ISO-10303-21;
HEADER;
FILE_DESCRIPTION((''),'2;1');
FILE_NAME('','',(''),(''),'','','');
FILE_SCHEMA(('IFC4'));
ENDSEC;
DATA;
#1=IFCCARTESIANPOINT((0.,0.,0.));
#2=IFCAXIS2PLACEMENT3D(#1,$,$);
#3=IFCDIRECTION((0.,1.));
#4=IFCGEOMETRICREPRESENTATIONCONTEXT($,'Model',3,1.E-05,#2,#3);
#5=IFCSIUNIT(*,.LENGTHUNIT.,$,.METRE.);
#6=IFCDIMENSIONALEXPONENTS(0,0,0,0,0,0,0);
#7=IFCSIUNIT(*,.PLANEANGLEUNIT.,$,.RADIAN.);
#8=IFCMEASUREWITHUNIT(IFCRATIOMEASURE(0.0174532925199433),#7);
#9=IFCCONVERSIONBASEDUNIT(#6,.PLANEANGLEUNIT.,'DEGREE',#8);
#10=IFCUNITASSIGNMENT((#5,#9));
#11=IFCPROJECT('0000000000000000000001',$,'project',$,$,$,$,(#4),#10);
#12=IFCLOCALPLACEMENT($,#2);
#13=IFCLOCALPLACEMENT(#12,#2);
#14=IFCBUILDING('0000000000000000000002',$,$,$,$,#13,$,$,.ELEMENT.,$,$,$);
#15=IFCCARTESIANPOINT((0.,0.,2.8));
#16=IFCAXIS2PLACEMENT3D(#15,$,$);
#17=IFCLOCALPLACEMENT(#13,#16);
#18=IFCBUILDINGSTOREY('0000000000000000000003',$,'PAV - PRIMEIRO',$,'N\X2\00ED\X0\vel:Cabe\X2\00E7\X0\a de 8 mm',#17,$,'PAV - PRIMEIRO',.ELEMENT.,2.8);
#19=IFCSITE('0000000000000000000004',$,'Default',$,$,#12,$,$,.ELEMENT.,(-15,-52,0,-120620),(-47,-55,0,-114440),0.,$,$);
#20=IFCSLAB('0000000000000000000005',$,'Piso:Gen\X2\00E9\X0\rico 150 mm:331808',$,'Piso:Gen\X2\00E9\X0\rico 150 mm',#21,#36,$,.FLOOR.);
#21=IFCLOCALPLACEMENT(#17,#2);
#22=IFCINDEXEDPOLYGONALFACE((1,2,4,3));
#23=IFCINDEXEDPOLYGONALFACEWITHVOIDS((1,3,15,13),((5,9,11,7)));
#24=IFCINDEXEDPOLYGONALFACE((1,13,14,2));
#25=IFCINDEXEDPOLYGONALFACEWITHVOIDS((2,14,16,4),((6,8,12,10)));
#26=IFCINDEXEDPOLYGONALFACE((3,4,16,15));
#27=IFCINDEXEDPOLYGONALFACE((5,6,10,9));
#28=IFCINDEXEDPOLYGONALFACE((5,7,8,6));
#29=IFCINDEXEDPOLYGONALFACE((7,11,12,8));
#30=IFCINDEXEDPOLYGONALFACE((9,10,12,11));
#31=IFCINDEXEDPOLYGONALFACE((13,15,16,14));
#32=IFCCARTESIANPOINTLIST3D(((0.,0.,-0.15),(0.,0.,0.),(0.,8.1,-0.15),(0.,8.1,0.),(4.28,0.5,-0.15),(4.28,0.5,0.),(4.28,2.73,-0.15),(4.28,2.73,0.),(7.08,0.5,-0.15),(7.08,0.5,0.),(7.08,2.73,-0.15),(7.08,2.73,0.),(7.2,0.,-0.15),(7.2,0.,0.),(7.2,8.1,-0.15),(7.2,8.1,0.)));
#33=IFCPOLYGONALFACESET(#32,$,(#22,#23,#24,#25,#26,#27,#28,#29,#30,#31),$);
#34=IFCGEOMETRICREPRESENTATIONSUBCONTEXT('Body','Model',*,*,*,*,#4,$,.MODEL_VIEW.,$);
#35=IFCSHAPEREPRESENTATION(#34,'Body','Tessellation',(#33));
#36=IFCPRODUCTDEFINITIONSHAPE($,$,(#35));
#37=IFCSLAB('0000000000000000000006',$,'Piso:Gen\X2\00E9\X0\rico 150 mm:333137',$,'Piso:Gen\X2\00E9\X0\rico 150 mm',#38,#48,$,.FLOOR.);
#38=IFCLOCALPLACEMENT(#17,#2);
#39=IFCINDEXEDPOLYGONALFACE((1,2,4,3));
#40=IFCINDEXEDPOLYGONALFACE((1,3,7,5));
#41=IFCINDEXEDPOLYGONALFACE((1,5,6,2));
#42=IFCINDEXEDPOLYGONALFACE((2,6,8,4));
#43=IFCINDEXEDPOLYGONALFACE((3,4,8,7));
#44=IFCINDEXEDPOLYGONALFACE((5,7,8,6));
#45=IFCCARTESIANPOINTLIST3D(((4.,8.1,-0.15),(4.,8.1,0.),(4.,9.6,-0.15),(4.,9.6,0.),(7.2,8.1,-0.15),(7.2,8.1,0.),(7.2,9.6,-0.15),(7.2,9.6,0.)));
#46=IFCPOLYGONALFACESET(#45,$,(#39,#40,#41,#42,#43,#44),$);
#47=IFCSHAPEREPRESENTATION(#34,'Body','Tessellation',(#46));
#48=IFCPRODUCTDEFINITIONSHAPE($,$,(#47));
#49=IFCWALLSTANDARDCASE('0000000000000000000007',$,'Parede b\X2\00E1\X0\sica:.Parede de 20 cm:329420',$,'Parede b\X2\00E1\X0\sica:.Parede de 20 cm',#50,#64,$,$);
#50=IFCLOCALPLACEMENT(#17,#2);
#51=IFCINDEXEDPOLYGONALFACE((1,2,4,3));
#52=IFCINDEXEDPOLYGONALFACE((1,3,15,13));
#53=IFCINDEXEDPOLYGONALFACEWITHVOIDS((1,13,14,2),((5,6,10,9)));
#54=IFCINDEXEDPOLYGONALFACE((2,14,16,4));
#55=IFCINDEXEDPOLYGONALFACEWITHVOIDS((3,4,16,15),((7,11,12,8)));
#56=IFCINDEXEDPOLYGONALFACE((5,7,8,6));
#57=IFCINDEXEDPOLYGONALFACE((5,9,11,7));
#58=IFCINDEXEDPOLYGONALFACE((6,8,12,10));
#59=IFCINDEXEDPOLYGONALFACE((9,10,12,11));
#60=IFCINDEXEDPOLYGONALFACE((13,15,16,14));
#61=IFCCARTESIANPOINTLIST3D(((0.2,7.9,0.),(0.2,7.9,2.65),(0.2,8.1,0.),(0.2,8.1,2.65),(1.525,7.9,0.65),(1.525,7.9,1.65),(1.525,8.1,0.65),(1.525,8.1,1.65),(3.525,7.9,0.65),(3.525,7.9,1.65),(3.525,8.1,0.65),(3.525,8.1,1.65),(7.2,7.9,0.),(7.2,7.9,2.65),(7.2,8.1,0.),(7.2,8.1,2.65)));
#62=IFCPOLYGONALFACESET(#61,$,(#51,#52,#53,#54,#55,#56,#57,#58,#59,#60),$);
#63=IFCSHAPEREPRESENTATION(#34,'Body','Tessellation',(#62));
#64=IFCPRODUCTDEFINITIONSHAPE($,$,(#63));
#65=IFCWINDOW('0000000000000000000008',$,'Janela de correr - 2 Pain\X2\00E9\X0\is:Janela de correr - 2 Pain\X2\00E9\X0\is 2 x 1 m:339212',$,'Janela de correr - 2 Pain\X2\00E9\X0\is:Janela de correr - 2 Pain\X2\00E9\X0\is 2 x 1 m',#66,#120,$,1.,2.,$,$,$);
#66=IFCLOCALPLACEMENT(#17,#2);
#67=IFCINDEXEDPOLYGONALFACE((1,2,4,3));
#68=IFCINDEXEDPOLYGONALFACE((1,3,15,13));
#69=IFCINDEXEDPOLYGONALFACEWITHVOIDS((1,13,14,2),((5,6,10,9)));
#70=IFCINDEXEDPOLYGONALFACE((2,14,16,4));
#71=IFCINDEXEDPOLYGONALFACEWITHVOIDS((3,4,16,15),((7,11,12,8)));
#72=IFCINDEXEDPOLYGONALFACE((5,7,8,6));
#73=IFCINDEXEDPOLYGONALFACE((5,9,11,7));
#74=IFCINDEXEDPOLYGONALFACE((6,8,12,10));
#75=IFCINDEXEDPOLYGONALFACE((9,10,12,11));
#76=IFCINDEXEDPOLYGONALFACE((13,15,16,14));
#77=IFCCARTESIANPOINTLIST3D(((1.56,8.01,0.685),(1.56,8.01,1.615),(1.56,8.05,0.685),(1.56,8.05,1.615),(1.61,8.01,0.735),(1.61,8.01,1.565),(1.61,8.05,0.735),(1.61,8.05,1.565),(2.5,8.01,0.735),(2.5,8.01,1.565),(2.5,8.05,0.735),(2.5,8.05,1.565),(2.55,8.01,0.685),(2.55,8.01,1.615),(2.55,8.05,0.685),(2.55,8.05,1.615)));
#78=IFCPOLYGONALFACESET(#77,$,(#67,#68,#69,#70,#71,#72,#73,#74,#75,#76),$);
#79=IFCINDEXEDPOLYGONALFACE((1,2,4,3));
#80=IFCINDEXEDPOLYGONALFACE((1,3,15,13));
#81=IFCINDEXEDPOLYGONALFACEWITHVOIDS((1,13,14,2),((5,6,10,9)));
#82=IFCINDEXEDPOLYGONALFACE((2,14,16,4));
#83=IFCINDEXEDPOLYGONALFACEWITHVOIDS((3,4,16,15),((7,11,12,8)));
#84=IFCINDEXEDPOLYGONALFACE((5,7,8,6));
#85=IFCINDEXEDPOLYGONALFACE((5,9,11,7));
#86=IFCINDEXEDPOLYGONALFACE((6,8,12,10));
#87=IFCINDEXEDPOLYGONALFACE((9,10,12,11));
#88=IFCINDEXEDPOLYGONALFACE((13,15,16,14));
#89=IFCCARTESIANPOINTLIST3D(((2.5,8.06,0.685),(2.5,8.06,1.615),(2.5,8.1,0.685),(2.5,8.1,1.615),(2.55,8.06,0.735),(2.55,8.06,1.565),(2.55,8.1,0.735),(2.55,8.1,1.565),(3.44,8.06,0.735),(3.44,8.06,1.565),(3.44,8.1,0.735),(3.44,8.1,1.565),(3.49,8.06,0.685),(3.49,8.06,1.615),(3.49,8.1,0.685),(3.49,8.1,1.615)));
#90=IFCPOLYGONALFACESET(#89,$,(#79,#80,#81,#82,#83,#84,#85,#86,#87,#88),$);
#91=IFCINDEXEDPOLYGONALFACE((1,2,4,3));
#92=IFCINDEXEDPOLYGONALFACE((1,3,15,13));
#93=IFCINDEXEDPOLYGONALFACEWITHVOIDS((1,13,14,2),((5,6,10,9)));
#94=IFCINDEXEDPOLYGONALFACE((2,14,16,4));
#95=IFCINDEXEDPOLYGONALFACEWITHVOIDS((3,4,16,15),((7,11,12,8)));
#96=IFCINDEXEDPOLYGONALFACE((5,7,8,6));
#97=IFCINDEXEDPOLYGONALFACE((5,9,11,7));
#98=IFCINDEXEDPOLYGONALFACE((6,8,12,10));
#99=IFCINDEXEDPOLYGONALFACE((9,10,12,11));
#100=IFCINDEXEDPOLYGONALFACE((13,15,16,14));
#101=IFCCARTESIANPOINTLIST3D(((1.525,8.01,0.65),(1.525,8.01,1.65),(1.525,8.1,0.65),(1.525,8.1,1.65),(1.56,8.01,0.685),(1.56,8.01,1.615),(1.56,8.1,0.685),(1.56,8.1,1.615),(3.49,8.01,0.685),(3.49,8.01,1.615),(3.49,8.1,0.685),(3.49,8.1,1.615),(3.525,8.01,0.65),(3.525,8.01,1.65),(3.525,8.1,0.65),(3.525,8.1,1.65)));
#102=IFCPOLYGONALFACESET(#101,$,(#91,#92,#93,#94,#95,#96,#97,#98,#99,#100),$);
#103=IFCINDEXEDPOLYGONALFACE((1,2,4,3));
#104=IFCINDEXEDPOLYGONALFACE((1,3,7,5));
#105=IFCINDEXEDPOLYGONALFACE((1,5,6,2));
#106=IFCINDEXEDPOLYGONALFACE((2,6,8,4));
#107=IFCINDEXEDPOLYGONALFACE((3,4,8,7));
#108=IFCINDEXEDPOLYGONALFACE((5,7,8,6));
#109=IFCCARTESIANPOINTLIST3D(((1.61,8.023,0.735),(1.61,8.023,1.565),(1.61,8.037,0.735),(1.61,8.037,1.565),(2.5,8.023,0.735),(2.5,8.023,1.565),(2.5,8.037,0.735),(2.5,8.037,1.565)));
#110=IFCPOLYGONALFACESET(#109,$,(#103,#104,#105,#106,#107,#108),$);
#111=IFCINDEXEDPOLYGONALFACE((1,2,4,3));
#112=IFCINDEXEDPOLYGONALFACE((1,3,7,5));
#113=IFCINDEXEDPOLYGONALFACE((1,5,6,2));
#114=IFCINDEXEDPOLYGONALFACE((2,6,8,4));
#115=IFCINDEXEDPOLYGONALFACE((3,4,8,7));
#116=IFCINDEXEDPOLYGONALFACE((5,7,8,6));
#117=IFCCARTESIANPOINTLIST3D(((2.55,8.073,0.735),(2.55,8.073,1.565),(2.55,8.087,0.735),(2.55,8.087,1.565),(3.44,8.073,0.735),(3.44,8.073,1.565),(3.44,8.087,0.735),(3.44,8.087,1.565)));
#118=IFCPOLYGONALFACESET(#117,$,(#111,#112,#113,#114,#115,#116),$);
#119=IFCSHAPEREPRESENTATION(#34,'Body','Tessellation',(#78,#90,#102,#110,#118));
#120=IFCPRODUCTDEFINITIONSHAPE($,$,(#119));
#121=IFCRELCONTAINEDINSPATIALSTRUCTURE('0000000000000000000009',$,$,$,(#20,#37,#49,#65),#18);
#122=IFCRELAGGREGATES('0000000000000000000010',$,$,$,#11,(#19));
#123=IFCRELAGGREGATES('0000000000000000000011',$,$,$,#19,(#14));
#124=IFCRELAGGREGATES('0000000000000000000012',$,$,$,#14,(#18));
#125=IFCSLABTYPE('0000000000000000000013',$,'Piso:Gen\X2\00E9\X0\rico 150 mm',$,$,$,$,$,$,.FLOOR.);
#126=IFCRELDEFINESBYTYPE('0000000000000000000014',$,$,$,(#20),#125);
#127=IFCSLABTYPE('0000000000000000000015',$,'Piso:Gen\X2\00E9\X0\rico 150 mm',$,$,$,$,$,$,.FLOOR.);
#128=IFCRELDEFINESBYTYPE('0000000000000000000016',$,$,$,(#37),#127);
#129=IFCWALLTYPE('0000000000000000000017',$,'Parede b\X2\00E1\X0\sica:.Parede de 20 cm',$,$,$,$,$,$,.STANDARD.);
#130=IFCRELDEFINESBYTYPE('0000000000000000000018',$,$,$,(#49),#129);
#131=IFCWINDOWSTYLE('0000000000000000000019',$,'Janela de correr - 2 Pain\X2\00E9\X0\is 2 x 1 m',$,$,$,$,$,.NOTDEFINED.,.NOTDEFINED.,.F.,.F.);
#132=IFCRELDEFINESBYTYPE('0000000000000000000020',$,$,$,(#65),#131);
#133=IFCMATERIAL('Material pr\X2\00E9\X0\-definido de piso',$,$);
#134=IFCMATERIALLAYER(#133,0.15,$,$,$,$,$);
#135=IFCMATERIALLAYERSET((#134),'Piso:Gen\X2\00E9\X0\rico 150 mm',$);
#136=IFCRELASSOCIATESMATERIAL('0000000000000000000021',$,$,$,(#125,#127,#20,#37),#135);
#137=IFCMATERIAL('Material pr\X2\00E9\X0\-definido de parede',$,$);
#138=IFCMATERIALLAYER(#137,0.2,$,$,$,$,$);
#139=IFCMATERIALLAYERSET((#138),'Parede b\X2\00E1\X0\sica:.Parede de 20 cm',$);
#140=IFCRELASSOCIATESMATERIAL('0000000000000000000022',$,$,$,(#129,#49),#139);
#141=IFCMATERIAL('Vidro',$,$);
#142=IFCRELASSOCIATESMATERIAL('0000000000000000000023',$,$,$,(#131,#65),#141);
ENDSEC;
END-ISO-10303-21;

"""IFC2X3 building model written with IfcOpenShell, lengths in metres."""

from ifc_helpers import new_model, entity, si_unit, converted_unit, direction, frame, frame_2d, origin, origin_2d_with_axis, place, context, subcontext, project, spatial, polyline, rectangle, outline, extrude, clip, bounded_halfspace, source, transform, mapped, material, layer, layer_set, layer_usage, type_object, type_shapes, element, fill, save


model = new_model("IFC2X3")

# Units and contexts
model_context = context("Model", 3, precision=1e-05, world=origin(), true_north=direction((0.0, 1.0)))
body_context = subcontext(model_context, "Body", "Model", "MODEL_VIEW")
ifc_project = project(units=[si_unit("LENGTHUNIT", "METRE"), converted_unit("PLANEANGLEUNIT", "DEGREE", entity("IfcRatioMeasure", 0.0174532925199433), si_unit("PLANEANGLEUNIT", "RADIAN"), dimensions=[0, 0, 0, 0, 0, 0, 0])], contexts=[model_context])

# Site, building, storey
site_placement = place(None, origin())
site = spatial("IfcSite", under=ifc_project, at=site_placement, Name="Default", CompositionType="ELEMENT", RefLatitude=(-15, -52, 0, -120620), RefLongitude=(-47, -55, 0, -114440), RefElevation=0.0)
building_placement = place(site_placement, origin())
building = spatial("IfcBuilding", under=site, at=building_placement, CompositionType="ELEMENT")
storey_placement = place(building_placement, frame((0.0, 0.0, 2.8)))
storey = spatial("IfcBuildingStorey", under=building, at=storey_placement, Name="PAV - PRIMEIRO", ObjectType="Nível:Cabeça de 8 mm", LongName="PAV - PRIMEIRO", CompositionType="ELEMENT", Elevation=2.8)

# Slab, opening
ifc_material_1 = material(Name="Material pré-definido de piso")
ifc_layer_1 = layer(ifc_material_1, 0.15)
ifc_layer_set_1 = layer_set([ifc_layer_1], Name="Piso:Genérico 150 mm")
ifc_layer_usage_1 = layer_usage(ifc_layer_set_1, "AXIS3", "POSITIVE", 0.0)
slab_type_1 = type_object("IfcSlabType", Name="Piso:Genérico 150 mm", PredefinedType="FLOOR", material=ifc_layer_set_1)
slab_1_placement = place(storey_placement, frame((0.0, 0.0, -0.15)))
slab_1 = element("IfcSlab", 1, at=slab_1_placement, inside=storey, type_object=slab_type_1, material=ifc_layer_usage_1, Name="Piso:Genérico 150 mm:331808", ObjectType="Piso:Genérico 150 mm", PredefinedType="FLOOR", context=body_context, shape_type="SweptSolid", body=[
    extrude(rectangle(XDim=8.1, YDim=7.2, at=frame_2d((0.0, 0.0), x_axis=(0.0, -1.0))), frame((3.6, 4.05, 0.15), z_axis=(0.0, 0.0, -1.0), x_axis=(-1.0, 0.0, 0.0)), (0.0, 0.0, 1.0), 0.15),
])
opening_1_placement = place(storey_placement, frame((0.0, 0.0, -0.15)))
element("IfcOpeningElement", 2, at=opening_1_placement, cuts=slab_1, ObjectType="Opening", context=body_context, shape_type="SweptSolid", body=[
    extrude(rectangle(XDim=2.23, YDim=2.8, at=frame_2d((-2.08, -2.435), x_axis=(0.0, 1.0))), frame((3.6, 4.05, 0.15), z_axis=(0.0, 0.0, -1.0), x_axis=(-1.0, 0.0, 0.0)), (0.0, 0.0, 1.0), 0.15),
])

# Slab
ifc_layer_usage_2 = layer_usage(ifc_layer_set_1, "AXIS3", "POSITIVE", 0.0)
slab_type_2 = type_object("IfcSlabType", Name="Piso:Genérico 150 mm", PredefinedType="FLOOR", material=ifc_layer_set_1)
slab_2_placement = place(storey_placement, origin())
element("IfcSlab", 3, at=slab_2_placement, inside=storey, type_object=slab_type_2, material=ifc_layer_usage_2, Name="Piso:Genérico 150 mm:333137", ObjectType="Piso:Genérico 150 mm", PredefinedType="FLOOR", context=body_context, shape_type="SweptSolid", body=[
    extrude(rectangle(XDim=1.5, YDim=3.2, at=frame_2d((0.0, 0.0), x_axis=(1.0, 0.0))), frame((5.6, 8.85, 0.0), z_axis=(0.0, 0.0, -1.0), x_axis=(0.0, 1.0, 0.0)), (0.0, 0.0, 1.0), 0.15),
])

# Shared definitions
ifc_material_2 = material(Name="Material pré-definido de parede")
ifc_layer_2 = layer(ifc_material_2, 0.2)
ifc_layer_set_2 = layer_set([ifc_layer_2], Name="Parede básica:.Parede de 20 cm")
wall_type_1 = type_object("IfcWallType", Name="Parede básica:.Parede de 20 cm", PredefinedType="STANDARD", material=ifc_layer_set_2)

# Wall, opening, window
ifc_layer_usage_3 = layer_usage(ifc_layer_set_2, "AXIS2", "NEGATIVE", 0.1)
wall_1_placement = place(storey_placement, frame((0.2, 8.0, 0.0)))
wall_1 = element("IfcWallStandardCase", 4, at=wall_1_placement, inside=storey, type_object=wall_type_1, material=ifc_layer_usage_3, Name="Parede básica:.Parede de 20 cm:329420", ObjectType="Parede básica:.Parede de 20 cm", context=body_context, shape_type="Clipping", body=[
    clip(extrude(rectangle(XDim=7.0, YDim=0.2, at=frame_2d((3.5, 0.0), x_axis=(-1.0, 0.0))), origin(), (0.0, 0.0, 1.0), 2.65), bounded_halfspace(frame((0.0, -0.1, 2.65), z_axis=(0.0, 0.0, -1.0), x_axis=(0.0, -1.0, 0.0)), True, frame((0.0, -0.1, 2.65)), polyline([(0.0, 0.0), (4.425, 0.0), (4.575, 0.0), (6.8, 0.0), (7.0, 0.0), (7.0, 0.2), (0.0, 0.2), (0.0, 0.0)]))),
])
opening_2_placement = place(wall_1_placement, frame((3.325, 0.1, 0.65)))
opening_2 = element("IfcOpeningElement", 5, at=opening_2_placement, cuts=wall_1, ObjectType="Opening", context=body_context, shape_type="SweptSolid", body=[
    extrude(rectangle(XDim=1.0, YDim=2.0, at=frame_2d((0.5, 1.0), x_axis=(1.0, 0.0))), frame((0.0, 0.0, 0.0), z_axis=(0.0, -1.0, 0.0), x_axis=(0.0, 0.0, 1.0)), (0.0, 0.0, 1.0), 0.2),
])
ifc_material_3 = material(Name="Vidro")
window_style_1 = type_object("IfcWindowStyle", Name="Janela de correr - 2 Painéis 2 x 1 m", ConstructionType="NOTDEFINED", OperationType="NOTDEFINED", ParameterTakesPrecedence=False, Sizeable=False, material=ifc_material_3)
shared_shape_1 = source(origin(), body_context, "Body", "SweptSolid", [
    extrude(outline(polyline([(-0.465, -0.495), (0.465, -0.495), (0.465, 0.495), (-0.465, 0.495), (-0.465, -0.495)]), holes=[polyline([(0.415, -0.445), (-0.415, -0.445), (-0.415, 0.445), (0.415, 0.445), (0.415, -0.445)])]), frame((1.47, 0.05, 0.5), z_axis=(0.0, 1.0, 0.0), x_axis=(0.0, 0.0, 1.0)), (0.0, 0.0, 1.0), 0.04),
    extrude(outline(polyline([(-0.465, -0.495), (0.465, -0.495), (0.465, 0.495), (-0.465, 0.495), (-0.465, -0.495)]), holes=[polyline([(0.415, -0.445), (-0.415, -0.445), (-0.415, 0.445), (0.415, 0.445), (0.415, -0.445)])]), frame((0.53, 0.0, 0.5), z_axis=(0.0, 1.0, 0.0), x_axis=(0.0, 0.0, -1.0)), (0.0, 0.0, 1.0), 0.04),
    extrude(outline(polyline([(-0.5, -1.0), (0.5, -1.0), (0.5, 1.0), (-0.5, 1.0), (-0.5, -1.0)]), holes=[polyline([(0.465, -0.965), (-0.465, -0.965), (-0.465, 0.965), (0.465, 0.965), (0.465, -0.965)])]), frame((1.0, 0.0, 0.5), z_axis=(0.0, 1.0, 0.0), x_axis=(0.0, 0.0, -1.0)), (0.0, 0.0, 1.0), 0.09),
    extrude(rectangle(XDim=0.014, YDim=0.89, at=frame_2d((0.0, 0.0), x_axis=(1.0, 0.0))), frame((1.47, 0.07, 0.085), z_axis=(0.0, 0.0, 1.0), x_axis=(0.0, -1.0, 0.0)), (0.0, 0.0, 1.0), 0.83),
    extrude(rectangle(XDim=0.014, YDim=0.89, at=origin_2d_with_axis()), frame((0.53, 0.02, 0.085), z_axis=(0.0, 0.0, 1.0), x_axis=(0.0, -1.0, 0.0)), (0.0, 0.0, 1.0), 0.83),
])
type_shapes(window_style_1, [shared_shape_1])
window_1_placement = place(opening_2_placement, frame((0.0, 0.0, 0.0), z_axis=(0.0, 0.0, 1.0), x_axis=(-1.0, 0.0, 0.0)))
window_1 = element("IfcWindow", 6, at=window_1_placement, inside=storey, type_object=window_style_1, material=ifc_material_3, Name="Janela de correr - 2 Painéis:Janela de correr - 2 Painéis 2 x 1 m:339212", ObjectType="Janela de correr - 2 Painéis:Janela de correr - 2 Painéis 2 x 1 m", OverallHeight=1.0, OverallWidth=2.0, context=body_context, shape_type="MappedRepresentation", body=[
    mapped(shared_shape_1, transform((0.0, 0.0, 0.0), scale=1.0)),
])
fill(opening_2, window_1)

save(model, "model.ifc")
